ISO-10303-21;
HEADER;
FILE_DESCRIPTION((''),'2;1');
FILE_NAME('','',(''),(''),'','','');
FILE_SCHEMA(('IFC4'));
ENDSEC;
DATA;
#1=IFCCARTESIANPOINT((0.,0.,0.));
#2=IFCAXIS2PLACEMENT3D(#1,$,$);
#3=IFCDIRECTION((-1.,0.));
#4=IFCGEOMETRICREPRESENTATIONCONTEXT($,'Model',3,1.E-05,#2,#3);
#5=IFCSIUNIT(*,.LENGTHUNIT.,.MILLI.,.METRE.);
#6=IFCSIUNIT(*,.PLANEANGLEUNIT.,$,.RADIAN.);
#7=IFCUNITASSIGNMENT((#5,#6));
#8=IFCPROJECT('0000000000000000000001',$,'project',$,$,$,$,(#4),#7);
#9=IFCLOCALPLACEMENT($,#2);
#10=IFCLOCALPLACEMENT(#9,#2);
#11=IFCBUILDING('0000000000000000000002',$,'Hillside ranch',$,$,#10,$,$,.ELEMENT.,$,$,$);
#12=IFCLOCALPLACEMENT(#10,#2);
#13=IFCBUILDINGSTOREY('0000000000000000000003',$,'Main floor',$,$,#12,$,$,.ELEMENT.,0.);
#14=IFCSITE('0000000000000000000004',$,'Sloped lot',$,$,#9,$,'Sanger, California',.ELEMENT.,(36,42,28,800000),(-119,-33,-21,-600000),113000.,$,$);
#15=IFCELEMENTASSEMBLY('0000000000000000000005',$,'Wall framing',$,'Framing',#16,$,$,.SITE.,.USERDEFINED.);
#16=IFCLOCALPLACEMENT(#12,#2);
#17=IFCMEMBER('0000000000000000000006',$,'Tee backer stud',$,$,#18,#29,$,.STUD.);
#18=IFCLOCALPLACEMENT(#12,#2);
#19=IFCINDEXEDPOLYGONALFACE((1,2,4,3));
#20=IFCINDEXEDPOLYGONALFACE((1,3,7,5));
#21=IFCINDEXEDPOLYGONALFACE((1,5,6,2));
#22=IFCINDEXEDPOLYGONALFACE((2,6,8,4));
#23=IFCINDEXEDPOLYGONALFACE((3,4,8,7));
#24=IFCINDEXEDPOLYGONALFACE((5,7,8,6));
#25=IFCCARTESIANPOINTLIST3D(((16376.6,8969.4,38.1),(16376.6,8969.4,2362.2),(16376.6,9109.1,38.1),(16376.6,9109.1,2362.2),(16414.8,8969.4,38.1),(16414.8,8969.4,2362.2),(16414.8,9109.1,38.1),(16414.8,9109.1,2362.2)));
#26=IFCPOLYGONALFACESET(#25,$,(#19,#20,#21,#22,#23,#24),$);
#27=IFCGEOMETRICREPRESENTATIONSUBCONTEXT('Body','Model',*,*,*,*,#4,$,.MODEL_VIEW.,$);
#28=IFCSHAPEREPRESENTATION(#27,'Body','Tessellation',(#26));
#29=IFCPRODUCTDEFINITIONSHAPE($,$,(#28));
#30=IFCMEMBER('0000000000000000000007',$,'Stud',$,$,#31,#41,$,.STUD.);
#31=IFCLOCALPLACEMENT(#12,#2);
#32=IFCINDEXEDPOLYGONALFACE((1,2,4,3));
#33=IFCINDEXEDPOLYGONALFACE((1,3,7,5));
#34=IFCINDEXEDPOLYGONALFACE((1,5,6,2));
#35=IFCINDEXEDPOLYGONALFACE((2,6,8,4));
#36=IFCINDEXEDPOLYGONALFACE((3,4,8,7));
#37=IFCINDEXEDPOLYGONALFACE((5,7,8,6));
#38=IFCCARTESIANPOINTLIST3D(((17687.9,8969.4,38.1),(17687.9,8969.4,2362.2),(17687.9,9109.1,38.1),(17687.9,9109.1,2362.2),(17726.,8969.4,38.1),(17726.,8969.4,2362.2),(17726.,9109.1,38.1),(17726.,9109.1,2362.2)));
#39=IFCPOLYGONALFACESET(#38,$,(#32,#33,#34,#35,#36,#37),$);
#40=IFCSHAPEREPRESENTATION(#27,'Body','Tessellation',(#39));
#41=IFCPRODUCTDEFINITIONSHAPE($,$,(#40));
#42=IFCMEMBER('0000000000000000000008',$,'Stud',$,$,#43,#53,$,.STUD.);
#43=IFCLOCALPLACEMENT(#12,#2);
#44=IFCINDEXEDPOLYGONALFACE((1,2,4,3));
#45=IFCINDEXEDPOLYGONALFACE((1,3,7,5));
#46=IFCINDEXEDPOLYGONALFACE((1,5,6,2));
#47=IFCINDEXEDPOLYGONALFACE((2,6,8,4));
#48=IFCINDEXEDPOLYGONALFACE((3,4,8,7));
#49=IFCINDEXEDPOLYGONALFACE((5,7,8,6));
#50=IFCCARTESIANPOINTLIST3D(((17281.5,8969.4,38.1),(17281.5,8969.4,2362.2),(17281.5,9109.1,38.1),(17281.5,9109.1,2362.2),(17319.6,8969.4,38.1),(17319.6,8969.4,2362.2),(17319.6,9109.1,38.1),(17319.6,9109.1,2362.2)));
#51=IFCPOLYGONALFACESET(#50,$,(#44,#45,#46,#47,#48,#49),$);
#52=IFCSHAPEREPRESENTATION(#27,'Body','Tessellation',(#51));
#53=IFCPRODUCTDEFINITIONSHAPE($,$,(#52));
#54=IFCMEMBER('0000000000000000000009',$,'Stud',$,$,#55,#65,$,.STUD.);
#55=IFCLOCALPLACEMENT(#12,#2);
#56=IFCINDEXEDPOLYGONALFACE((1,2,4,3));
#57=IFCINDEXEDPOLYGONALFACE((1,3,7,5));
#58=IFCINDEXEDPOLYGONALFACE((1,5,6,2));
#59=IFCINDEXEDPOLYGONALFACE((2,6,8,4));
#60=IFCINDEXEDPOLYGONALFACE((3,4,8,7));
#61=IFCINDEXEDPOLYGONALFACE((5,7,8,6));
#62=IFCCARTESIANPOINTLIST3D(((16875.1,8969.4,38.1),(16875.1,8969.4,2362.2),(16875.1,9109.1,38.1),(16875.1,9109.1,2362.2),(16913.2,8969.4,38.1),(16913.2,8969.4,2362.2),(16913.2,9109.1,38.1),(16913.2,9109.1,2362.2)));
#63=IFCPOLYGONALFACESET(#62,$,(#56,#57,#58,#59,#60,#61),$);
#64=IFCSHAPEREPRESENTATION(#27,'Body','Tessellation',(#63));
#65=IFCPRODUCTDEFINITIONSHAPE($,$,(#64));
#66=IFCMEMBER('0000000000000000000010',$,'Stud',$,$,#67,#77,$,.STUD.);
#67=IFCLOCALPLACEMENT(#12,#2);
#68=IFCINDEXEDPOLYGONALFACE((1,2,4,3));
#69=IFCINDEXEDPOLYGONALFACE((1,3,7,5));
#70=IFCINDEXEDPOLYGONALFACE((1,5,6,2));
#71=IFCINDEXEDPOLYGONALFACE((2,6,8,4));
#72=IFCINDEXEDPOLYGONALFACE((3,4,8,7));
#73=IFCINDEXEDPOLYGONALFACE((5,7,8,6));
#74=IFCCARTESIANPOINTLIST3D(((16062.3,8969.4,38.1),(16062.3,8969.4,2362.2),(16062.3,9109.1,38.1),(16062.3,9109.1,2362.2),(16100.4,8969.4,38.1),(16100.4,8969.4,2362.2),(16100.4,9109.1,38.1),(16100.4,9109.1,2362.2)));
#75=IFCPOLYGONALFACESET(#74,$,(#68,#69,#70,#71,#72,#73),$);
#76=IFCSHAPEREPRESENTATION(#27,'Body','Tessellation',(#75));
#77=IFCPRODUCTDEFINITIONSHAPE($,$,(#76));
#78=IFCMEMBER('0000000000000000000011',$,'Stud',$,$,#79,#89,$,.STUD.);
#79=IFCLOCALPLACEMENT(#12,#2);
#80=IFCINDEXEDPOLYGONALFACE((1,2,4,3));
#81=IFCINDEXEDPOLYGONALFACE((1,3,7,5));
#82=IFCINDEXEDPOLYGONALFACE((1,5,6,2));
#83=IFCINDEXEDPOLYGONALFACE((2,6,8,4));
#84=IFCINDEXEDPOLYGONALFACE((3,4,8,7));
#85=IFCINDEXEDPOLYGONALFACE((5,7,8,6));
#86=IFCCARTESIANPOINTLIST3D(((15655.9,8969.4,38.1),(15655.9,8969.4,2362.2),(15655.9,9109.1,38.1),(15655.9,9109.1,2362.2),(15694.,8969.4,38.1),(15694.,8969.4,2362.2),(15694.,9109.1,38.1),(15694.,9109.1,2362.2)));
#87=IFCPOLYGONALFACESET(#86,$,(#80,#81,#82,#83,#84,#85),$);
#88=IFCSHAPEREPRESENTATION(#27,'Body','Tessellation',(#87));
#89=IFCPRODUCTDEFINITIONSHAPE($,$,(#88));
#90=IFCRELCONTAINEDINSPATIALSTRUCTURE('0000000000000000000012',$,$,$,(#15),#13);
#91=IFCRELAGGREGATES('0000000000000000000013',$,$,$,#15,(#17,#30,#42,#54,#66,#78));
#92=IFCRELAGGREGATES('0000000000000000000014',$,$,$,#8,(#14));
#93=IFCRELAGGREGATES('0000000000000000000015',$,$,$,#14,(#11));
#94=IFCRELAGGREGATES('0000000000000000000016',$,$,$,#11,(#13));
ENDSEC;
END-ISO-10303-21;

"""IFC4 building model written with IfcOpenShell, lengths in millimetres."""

from ifc_helpers import new_model, si_unit, direction, frame, origin, origin_with_axes, place, context, subcontext, project, spatial, polyline, outline, extrude, element, aggregate, save


model = new_model("IFC4")

# Units and contexts
model_context = context("Model", 3, precision=1e-05, world=origin(), true_north=direction((-1.0, 0.0)))
body_context = subcontext(model_context, "Body", "Model", "MODEL_VIEW")
ifc_project = project(units=[si_unit("LENGTHUNIT", "METRE", prefix="MILLI"), si_unit("PLANEANGLEUNIT", "RADIAN")], contexts=[model_context])

# Site, building, storey
site_placement = place(None, origin())
site = spatial("IfcSite", under=ifc_project, at=site_placement, Name="Sloped lot", LongName="Sanger, California", CompositionType="ELEMENT", RefLatitude=(36, 42, 28, 800000), RefLongitude=(-119, -33, -21, -600000), RefElevation=113000.0)
building_placement = place(site_placement, origin())
building = spatial("IfcBuilding", under=site, at=building_placement, Name="Hillside ranch", CompositionType="ELEMENT")
storey_placement = place(building_placement, origin())
storey = spatial("IfcBuildingStorey", under=building, at=storey_placement, Name="Main floor", CompositionType="ELEMENT", Elevation=0.0)

# Element assembly, members
assembly_placement = place(storey_placement, origin_with_axes())
assembly = element("IfcElementAssembly", 1, at=assembly_placement, inside=storey, Name="Wall framing", ObjectType="Framing", AssemblyPlace="SITE", PredefinedType="USERDEFINED")
member_1_placement = place(storey_placement, origin_with_axes())
member_1 = element("IfcMember", 2, at=member_1_placement, Name="Tee backer stud", PredefinedType="STUD", context=body_context, shape_type="SweptSolid", body=[
    extrude(outline(polyline([(0.0, 0.0), (38.1, 0.0), (38.1, 139.7), (0.0, 139.7), (0.0, 0.0)])), frame((16414.8, 9109.1, 38.1), z_axis=(0.0, 0.0, 1.0), x_axis=(-1.0, 0.0, 0.0)), (0.0, 0.0, 1.0), 2324.1),
])
member_2_placement = place(storey_placement, origin_with_axes())
member_2 = element("IfcMember", 3, at=member_2_placement, Name="Stud", PredefinedType="STUD", context=body_context, shape_type="SweptSolid", body=[
    extrude(outline(polyline([(0.0, 0.0), (38.1, 0.0), (38.1, 139.7), (0.0, 139.7), (0.0, 0.0)])), frame((17726.0, 9109.1, 38.1), z_axis=(0.0, 0.0, 1.0), x_axis=(-1.0, 0.0, 0.0)), (0.0, 0.0, 1.0), 2324.1),
])
member_3_placement = place(storey_placement, origin_with_axes())
member_3 = element("IfcMember", 4, at=member_3_placement, Name="Stud", PredefinedType="STUD", context=body_context, shape_type="SweptSolid", body=[
    extrude(outline(polyline([(0.0, 0.0), (38.1, 0.0), (38.1, 139.7), (0.0, 139.7), (0.0, 0.0)])), frame((17319.6, 9109.1, 38.1), z_axis=(0.0, 0.0, 1.0), x_axis=(-1.0, 0.0, 0.0)), (0.0, 0.0, 1.0), 2324.1),
])
member_4_placement = place(storey_placement, origin_with_axes())
member_4 = element("IfcMember", 5, at=member_4_placement, Name="Stud", PredefinedType="STUD", context=body_context, shape_type="SweptSolid", body=[
    extrude(outline(polyline([(0.0, 0.0), (38.1, 0.0), (38.1, 139.7), (0.0, 139.7), (0.0, 0.0)])), frame((16913.2, 9109.1, 38.1), z_axis=(0.0, 0.0, 1.0), x_axis=(-1.0, 0.0, 0.0)), (0.0, 0.0, 1.0), 2324.1),
])
member_5_placement = place(storey_placement, origin_with_axes())
member_5 = element("IfcMember", 6, at=member_5_placement, Name="Stud", PredefinedType="STUD", context=body_context, shape_type="SweptSolid", body=[
    extrude(outline(polyline([(0.0, 0.0), (38.1, 0.0), (38.1, 139.7), (0.0, 139.7), (0.0, 0.0)])), frame((16100.4, 9109.1, 38.1), z_axis=(0.0, 0.0, 1.0), x_axis=(-1.0, 0.0, 0.0)), (0.0, 0.0, 1.0), 2324.1),
])
member_6_placement = place(storey_placement, origin_with_axes())
member_6 = element("IfcMember", 7, at=member_6_placement, Name="Stud", PredefinedType="STUD", context=body_context, shape_type="SweptSolid", body=[
    extrude(outline(polyline([(0.0, 0.0), (38.1, 0.0), (38.1, 139.7), (0.0, 139.7), (0.0, 0.0)])), frame((15694.0, 9109.1, 38.1), z_axis=(0.0, 0.0, 1.0), x_axis=(-1.0, 0.0, 0.0)), (0.0, 0.0, 1.0), 2324.1),
])
aggregate(assembly, [member_1, member_2, member_3, member_4, member_5, member_6])

save(model, "model.ifc")
